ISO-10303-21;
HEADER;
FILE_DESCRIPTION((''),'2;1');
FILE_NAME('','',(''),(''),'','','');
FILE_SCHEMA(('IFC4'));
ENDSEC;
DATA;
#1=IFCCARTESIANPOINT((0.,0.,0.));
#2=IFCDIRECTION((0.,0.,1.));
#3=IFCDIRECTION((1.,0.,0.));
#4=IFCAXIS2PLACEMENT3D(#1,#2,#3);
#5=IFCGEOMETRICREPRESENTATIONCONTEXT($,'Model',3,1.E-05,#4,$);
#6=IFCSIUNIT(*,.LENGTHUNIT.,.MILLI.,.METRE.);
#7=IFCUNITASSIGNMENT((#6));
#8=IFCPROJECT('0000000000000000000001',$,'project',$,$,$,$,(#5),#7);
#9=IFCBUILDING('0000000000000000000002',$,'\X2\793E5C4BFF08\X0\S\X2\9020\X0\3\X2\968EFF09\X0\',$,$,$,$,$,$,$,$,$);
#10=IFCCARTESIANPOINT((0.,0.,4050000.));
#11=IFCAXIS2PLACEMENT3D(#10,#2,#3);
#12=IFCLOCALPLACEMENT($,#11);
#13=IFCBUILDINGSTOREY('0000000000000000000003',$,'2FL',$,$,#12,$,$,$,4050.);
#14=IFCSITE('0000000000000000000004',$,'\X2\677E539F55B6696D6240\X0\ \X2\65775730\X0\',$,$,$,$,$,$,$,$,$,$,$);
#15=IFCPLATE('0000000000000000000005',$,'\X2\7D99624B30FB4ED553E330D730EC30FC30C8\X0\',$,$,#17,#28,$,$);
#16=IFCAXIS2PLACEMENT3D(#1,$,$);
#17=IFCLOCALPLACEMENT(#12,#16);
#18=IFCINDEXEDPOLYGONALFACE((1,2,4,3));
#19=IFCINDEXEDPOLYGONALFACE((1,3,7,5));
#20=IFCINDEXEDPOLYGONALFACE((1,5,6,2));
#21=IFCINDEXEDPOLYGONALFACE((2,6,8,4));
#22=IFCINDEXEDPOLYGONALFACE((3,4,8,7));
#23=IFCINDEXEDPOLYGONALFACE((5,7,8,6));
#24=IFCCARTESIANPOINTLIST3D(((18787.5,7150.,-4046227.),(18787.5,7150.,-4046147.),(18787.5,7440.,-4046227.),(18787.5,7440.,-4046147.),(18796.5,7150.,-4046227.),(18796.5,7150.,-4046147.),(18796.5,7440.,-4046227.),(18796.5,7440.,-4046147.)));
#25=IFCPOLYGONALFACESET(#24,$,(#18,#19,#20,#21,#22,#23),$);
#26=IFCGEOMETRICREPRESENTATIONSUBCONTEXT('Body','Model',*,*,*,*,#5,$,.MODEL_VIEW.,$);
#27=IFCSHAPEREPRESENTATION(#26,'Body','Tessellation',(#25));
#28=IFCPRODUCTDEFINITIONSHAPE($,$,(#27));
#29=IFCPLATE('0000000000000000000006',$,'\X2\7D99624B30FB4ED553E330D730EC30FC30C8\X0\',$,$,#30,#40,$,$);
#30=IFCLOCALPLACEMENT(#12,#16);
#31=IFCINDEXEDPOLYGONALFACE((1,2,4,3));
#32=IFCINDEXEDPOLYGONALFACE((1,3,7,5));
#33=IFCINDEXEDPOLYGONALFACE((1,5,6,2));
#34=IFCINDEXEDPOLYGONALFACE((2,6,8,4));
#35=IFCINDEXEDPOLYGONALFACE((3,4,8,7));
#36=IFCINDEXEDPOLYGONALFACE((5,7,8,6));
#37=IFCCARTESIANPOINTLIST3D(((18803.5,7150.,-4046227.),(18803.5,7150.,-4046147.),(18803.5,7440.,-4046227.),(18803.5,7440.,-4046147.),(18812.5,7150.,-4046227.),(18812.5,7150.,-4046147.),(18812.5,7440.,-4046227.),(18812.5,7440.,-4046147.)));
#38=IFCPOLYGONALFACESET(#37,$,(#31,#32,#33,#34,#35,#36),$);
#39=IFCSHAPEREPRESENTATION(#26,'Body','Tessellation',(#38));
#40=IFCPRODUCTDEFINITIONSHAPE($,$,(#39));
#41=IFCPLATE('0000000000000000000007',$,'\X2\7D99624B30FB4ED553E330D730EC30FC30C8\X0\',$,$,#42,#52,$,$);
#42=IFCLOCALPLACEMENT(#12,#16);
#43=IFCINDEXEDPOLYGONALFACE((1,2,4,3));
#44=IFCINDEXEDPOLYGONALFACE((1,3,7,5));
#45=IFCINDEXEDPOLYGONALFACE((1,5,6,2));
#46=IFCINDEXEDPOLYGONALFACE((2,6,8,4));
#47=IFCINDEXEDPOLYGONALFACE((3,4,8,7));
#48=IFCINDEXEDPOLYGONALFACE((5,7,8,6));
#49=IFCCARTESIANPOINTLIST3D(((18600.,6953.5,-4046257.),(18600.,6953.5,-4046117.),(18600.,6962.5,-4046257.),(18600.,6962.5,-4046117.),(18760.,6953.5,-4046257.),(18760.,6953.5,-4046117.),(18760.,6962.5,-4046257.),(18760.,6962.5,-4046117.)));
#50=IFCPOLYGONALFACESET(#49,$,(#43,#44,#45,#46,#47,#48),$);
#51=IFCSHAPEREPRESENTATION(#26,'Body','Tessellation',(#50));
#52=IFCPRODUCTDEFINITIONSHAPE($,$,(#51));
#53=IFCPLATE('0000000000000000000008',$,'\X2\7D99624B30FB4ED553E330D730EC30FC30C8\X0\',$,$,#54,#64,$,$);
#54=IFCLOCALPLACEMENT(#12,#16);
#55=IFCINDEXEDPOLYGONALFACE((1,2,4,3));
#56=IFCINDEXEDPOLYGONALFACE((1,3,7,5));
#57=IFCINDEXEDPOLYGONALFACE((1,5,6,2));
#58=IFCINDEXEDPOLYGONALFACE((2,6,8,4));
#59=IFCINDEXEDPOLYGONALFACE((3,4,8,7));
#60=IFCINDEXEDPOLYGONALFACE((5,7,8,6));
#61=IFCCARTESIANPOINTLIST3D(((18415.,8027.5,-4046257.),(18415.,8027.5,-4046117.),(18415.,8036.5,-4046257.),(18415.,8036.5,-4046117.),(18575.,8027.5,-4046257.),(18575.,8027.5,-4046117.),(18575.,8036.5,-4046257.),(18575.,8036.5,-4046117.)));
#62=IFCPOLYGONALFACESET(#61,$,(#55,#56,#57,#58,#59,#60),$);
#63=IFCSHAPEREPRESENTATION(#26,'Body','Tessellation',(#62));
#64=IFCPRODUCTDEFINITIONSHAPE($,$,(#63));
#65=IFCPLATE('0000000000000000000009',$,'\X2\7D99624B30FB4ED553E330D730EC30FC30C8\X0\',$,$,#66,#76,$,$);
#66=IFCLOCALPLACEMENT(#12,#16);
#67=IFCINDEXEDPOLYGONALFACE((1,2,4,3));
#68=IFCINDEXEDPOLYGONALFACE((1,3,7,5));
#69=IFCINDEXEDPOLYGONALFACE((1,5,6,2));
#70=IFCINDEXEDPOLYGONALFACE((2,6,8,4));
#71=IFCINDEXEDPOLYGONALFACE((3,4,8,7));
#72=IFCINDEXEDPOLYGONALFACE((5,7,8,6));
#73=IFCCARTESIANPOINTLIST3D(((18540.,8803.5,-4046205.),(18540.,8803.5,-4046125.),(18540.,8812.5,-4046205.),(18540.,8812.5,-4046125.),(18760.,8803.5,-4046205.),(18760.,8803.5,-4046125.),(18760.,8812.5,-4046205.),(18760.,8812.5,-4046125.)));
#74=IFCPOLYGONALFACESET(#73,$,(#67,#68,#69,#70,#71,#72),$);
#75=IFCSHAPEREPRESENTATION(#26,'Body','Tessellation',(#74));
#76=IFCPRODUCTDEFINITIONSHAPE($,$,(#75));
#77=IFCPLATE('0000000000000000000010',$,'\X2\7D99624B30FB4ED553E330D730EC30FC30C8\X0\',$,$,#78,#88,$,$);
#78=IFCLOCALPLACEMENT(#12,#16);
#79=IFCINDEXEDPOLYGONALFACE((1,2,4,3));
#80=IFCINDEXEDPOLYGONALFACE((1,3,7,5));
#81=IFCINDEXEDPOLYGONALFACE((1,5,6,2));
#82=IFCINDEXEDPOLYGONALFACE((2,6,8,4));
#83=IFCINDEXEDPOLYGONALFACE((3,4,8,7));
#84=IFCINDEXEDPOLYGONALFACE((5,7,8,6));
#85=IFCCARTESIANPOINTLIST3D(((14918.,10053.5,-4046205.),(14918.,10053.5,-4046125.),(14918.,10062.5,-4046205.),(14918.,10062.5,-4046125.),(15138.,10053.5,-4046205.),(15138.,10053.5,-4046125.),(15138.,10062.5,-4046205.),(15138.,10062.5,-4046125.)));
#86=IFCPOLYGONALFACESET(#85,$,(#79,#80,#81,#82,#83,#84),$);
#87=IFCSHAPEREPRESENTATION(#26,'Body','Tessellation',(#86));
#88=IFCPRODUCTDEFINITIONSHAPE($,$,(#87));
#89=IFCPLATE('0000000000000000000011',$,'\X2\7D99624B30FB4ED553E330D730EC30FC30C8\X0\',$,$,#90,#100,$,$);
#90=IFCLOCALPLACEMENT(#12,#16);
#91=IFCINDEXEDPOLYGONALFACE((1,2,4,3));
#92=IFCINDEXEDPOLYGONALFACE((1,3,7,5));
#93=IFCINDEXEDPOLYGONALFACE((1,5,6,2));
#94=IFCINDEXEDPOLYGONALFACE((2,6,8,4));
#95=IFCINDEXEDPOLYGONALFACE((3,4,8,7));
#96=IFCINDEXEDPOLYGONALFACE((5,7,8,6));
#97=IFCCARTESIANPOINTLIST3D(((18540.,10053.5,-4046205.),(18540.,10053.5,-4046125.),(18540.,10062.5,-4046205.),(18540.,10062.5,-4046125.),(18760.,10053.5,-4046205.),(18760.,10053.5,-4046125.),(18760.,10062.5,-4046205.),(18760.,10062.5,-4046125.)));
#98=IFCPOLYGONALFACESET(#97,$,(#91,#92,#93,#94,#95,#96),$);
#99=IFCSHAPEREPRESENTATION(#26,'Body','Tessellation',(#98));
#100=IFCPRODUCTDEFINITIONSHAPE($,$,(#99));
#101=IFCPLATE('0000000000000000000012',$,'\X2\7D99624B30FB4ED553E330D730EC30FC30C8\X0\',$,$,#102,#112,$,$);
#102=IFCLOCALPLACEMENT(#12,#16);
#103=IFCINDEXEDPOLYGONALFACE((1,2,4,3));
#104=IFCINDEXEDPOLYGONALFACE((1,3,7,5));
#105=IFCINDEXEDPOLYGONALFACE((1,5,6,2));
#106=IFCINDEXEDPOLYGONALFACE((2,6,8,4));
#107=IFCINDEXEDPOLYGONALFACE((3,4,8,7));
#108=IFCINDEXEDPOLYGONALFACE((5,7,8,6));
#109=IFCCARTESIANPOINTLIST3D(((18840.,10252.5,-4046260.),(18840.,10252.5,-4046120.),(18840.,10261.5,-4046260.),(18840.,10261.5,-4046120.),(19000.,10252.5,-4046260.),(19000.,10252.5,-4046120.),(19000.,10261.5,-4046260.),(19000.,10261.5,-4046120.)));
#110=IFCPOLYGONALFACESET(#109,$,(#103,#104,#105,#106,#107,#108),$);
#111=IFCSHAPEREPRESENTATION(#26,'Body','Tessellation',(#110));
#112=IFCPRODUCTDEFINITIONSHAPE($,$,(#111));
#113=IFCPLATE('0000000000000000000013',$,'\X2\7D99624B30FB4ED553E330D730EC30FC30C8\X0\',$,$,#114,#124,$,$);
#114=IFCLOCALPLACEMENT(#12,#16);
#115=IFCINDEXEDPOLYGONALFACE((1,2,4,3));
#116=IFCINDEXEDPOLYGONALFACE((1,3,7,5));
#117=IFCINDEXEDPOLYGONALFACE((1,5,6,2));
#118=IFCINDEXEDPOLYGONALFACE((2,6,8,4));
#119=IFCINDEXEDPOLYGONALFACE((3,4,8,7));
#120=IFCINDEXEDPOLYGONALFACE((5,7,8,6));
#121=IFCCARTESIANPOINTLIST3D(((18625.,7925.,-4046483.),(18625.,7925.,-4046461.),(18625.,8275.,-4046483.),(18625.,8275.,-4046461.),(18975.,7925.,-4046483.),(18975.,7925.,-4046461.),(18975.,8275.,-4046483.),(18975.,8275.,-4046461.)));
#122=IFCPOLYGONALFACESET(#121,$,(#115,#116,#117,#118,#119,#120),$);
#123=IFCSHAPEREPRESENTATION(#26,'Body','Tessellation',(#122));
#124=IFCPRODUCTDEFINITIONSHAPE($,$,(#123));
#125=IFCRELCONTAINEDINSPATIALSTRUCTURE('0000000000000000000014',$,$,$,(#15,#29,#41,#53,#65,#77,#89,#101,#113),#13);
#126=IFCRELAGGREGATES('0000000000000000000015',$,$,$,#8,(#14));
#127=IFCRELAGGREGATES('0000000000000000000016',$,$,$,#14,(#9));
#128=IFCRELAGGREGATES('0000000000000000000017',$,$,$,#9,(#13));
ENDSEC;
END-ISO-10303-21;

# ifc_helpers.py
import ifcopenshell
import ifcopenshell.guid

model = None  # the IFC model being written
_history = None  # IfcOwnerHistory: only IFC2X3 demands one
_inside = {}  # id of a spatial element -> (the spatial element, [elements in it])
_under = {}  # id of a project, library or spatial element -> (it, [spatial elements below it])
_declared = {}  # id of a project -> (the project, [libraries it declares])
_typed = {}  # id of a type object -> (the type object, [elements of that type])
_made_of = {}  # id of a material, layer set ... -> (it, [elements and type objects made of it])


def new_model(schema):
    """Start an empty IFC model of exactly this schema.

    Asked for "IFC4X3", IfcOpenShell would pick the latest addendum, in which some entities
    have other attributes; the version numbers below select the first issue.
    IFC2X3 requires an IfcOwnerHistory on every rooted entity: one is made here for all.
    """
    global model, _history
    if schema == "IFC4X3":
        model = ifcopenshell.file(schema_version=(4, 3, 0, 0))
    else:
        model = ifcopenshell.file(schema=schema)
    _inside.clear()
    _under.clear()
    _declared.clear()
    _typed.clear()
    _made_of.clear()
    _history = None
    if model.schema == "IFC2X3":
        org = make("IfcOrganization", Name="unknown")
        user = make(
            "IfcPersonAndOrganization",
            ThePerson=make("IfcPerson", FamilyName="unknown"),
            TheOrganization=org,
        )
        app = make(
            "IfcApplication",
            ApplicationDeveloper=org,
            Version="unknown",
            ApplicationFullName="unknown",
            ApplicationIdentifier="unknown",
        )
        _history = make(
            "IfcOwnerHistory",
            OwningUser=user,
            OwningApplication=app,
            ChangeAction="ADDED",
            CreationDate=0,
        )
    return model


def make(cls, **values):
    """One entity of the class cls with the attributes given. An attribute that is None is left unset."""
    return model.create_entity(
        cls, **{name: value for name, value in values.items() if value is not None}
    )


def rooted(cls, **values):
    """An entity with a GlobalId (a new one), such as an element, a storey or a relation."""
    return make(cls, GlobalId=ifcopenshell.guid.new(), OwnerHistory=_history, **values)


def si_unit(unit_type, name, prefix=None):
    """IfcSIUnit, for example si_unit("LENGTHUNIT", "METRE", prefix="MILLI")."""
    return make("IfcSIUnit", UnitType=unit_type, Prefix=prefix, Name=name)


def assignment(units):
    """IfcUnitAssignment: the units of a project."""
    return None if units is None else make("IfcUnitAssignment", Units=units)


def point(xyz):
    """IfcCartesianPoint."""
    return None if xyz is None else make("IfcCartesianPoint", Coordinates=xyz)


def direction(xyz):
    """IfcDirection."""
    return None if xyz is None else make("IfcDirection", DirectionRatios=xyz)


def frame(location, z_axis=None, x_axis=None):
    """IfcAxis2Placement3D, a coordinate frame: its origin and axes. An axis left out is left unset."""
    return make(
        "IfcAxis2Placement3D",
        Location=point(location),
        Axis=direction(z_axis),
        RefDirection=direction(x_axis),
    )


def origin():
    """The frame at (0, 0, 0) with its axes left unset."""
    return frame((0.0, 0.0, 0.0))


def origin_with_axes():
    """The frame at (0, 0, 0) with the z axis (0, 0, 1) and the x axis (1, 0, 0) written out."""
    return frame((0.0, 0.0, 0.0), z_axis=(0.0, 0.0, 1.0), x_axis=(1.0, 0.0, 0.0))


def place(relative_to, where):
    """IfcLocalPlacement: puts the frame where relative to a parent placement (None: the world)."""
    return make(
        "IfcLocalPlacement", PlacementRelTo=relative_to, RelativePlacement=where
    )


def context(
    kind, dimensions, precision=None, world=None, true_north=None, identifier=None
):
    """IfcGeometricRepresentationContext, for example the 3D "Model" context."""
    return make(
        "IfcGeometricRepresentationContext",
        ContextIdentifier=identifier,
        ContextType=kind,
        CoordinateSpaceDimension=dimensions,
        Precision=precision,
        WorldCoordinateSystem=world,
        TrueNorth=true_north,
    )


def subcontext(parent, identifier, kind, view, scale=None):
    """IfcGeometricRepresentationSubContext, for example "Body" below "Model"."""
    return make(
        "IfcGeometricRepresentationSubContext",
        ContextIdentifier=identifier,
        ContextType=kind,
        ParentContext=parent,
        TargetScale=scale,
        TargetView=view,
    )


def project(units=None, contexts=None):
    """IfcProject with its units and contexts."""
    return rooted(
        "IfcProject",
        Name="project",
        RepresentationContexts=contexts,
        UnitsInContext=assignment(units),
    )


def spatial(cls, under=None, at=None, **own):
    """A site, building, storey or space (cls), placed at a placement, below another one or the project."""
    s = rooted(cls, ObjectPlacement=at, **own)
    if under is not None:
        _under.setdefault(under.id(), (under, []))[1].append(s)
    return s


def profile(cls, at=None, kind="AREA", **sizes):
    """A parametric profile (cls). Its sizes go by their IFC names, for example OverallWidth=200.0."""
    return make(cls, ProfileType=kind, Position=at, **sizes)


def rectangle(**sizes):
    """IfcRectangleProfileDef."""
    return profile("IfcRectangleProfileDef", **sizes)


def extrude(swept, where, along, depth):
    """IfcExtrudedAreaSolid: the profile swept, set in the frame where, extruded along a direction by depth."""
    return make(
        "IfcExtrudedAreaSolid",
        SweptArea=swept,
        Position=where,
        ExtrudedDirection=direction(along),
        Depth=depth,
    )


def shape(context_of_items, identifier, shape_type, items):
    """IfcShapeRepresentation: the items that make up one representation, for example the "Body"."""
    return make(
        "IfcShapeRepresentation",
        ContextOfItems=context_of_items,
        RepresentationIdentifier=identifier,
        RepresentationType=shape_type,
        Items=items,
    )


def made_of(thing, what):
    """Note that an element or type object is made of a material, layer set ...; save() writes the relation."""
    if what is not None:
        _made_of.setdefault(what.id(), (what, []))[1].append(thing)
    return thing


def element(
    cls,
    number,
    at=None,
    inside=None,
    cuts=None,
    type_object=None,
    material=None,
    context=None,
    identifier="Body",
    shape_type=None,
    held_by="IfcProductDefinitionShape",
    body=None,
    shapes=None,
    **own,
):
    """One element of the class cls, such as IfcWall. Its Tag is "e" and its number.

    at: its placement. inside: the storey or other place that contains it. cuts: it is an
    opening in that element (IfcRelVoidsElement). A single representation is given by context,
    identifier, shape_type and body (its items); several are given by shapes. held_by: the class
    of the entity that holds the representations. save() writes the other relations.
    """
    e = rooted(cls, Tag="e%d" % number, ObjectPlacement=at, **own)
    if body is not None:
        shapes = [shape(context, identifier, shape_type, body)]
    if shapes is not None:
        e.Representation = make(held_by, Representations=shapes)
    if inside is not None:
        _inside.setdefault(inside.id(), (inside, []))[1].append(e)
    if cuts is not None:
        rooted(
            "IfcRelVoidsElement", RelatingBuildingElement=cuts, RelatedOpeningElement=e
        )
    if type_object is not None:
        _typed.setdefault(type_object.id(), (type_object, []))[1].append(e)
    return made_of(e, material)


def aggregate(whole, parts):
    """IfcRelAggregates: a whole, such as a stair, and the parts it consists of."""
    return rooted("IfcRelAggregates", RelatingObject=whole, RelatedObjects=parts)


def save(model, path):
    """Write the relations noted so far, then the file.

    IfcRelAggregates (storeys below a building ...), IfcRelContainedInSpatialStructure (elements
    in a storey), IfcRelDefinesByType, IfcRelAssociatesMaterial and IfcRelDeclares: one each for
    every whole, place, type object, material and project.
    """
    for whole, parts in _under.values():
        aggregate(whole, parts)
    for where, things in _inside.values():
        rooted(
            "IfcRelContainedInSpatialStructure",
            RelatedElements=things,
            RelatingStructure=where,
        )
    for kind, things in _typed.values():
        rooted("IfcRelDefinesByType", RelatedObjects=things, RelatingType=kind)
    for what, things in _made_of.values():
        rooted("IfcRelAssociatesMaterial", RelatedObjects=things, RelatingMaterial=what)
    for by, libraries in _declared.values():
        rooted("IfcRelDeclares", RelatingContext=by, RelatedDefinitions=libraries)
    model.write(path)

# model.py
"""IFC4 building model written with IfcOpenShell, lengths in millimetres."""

from ifc_helpers import new_model, si_unit, frame, origin, origin_with_axes, place, context, subcontext, project, spatial, rectangle, extrude, element, save


model = new_model("IFC4")

# Units and contexts
model_context = context("Model", 3, precision=1e-05, world=origin_with_axes())
body_context = subcontext(model_context, "Body", "Model", "MODEL_VIEW")
ifc_project = project(units=[si_unit("LENGTHUNIT", "METRE", prefix="MILLI")], contexts=[model_context])

# Site, building, storey
site = spatial("IfcSite", under=ifc_project, Name="松原営業所 敷地")
building = spatial("IfcBuilding", under=site, Name="社屋（S造3階）")
storey_placement = place(None, frame((0.0, 0.0, 4050000.0), z_axis=(0.0, 0.0, 1.0), x_axis=(1.0, 0.0, 0.0)))
storey = spatial("IfcBuildingStorey", under=building, at=storey_placement, Name="2FL", Elevation=4050.0)

# Plates
for number, where, z_axis, x_axis, name in (
    (1, (18792.0, 7150.0, -4046187.0), (0.0, 1.0, 0.0), (-1.0, 0.0, 0.0), "継手・仕口プレート"),
    (2, (18808.0, 7150.0, -4046187.0), (0.0, 1.0, 0.0), (-1.0, 0.0, 0.0), "継手・仕口プレート"),
):
    element("IfcPlate", number, at=place(storey_placement, frame(where, z_axis=z_axis, x_axis=x_axis)), inside=storey, Name=name, context=body_context, shape_type="SweptSolid", body=[
        extrude(rectangle(XDim=9.0, YDim=80.0), origin(), (0.0, 0.0, 1.0), 290.0),
    ])
for number, where, z_axis, x_axis, name in (
    (3, (18600.0, 6958.0, -4046187.0), (1.0, 0.0, 0.0), (0.0, 1.0, 0.0), "継手・仕口プレート"),
    (4, (18415.0, 8032.0, -4046187.0), (1.0, 0.0, 0.0), (0.0, 1.0, 0.0), "継手・仕口プレート"),
):
    element("IfcPlate", number, at=place(storey_placement, frame(where, z_axis=z_axis, x_axis=x_axis)), inside=storey, Name=name, context=body_context, shape_type="SweptSolid", body=[
        extrude(rectangle(XDim=9.0, YDim=140.0), origin(), (0.0, 0.0, 1.0), 160.0),
    ])
for number, where, z_axis, x_axis, name in (
    (5, (18540.0, 8808.0, -4046165.0), (1.0, 0.0, 0.0), (0.0, 1.0, 0.0), "継手・仕口プレート"),
    (6, (14918.0, 10058.0, -4046165.0), (1.0, 0.0, 0.0), (0.0, 1.0, 0.0), "継手・仕口プレート"),
    (7, (18540.0, 10058.0, -4046165.0), (1.0, 0.0, 0.0), (0.0, 1.0, 0.0), "継手・仕口プレート"),
):
    element("IfcPlate", number, at=place(storey_placement, frame(where, z_axis=z_axis, x_axis=x_axis)), inside=storey, Name=name, context=body_context, shape_type="SweptSolid", body=[
        extrude(rectangle(XDim=9.0, YDim=80.0), origin(), (0.0, 0.0, 1.0), 220.0),
    ])
plate_1_placement = place(storey_placement, frame((18840.0, 10257.0, -4046190.0), z_axis=(1.0, 0.0, 0.0), x_axis=(0.0, 1.0, 0.0)))
element("IfcPlate", 8, at=plate_1_placement, inside=storey, Name="継手・仕口プレート", context=body_context, shape_type="SweptSolid", body=[
    extrude(rectangle(XDim=9.0, YDim=140.0), origin(), (0.0, 0.0, 1.0), 160.0),
])
plate_2_placement = place(storey_placement, frame((18625.0, 8100.0, -4046472.0), z_axis=(1.0, 0.0, 0.0), x_axis=(0.0, 1.0, 0.0)))
element("IfcPlate", 9, at=plate_2_placement, inside=storey, Name="継手・仕口プレート", context=body_context, shape_type="SweptSolid", body=[
    extrude(rectangle(XDim=350.0, YDim=22.0), origin(), (0.0, 0.0, 1.0), 350.0),
])

save(model, "model.ifc")
